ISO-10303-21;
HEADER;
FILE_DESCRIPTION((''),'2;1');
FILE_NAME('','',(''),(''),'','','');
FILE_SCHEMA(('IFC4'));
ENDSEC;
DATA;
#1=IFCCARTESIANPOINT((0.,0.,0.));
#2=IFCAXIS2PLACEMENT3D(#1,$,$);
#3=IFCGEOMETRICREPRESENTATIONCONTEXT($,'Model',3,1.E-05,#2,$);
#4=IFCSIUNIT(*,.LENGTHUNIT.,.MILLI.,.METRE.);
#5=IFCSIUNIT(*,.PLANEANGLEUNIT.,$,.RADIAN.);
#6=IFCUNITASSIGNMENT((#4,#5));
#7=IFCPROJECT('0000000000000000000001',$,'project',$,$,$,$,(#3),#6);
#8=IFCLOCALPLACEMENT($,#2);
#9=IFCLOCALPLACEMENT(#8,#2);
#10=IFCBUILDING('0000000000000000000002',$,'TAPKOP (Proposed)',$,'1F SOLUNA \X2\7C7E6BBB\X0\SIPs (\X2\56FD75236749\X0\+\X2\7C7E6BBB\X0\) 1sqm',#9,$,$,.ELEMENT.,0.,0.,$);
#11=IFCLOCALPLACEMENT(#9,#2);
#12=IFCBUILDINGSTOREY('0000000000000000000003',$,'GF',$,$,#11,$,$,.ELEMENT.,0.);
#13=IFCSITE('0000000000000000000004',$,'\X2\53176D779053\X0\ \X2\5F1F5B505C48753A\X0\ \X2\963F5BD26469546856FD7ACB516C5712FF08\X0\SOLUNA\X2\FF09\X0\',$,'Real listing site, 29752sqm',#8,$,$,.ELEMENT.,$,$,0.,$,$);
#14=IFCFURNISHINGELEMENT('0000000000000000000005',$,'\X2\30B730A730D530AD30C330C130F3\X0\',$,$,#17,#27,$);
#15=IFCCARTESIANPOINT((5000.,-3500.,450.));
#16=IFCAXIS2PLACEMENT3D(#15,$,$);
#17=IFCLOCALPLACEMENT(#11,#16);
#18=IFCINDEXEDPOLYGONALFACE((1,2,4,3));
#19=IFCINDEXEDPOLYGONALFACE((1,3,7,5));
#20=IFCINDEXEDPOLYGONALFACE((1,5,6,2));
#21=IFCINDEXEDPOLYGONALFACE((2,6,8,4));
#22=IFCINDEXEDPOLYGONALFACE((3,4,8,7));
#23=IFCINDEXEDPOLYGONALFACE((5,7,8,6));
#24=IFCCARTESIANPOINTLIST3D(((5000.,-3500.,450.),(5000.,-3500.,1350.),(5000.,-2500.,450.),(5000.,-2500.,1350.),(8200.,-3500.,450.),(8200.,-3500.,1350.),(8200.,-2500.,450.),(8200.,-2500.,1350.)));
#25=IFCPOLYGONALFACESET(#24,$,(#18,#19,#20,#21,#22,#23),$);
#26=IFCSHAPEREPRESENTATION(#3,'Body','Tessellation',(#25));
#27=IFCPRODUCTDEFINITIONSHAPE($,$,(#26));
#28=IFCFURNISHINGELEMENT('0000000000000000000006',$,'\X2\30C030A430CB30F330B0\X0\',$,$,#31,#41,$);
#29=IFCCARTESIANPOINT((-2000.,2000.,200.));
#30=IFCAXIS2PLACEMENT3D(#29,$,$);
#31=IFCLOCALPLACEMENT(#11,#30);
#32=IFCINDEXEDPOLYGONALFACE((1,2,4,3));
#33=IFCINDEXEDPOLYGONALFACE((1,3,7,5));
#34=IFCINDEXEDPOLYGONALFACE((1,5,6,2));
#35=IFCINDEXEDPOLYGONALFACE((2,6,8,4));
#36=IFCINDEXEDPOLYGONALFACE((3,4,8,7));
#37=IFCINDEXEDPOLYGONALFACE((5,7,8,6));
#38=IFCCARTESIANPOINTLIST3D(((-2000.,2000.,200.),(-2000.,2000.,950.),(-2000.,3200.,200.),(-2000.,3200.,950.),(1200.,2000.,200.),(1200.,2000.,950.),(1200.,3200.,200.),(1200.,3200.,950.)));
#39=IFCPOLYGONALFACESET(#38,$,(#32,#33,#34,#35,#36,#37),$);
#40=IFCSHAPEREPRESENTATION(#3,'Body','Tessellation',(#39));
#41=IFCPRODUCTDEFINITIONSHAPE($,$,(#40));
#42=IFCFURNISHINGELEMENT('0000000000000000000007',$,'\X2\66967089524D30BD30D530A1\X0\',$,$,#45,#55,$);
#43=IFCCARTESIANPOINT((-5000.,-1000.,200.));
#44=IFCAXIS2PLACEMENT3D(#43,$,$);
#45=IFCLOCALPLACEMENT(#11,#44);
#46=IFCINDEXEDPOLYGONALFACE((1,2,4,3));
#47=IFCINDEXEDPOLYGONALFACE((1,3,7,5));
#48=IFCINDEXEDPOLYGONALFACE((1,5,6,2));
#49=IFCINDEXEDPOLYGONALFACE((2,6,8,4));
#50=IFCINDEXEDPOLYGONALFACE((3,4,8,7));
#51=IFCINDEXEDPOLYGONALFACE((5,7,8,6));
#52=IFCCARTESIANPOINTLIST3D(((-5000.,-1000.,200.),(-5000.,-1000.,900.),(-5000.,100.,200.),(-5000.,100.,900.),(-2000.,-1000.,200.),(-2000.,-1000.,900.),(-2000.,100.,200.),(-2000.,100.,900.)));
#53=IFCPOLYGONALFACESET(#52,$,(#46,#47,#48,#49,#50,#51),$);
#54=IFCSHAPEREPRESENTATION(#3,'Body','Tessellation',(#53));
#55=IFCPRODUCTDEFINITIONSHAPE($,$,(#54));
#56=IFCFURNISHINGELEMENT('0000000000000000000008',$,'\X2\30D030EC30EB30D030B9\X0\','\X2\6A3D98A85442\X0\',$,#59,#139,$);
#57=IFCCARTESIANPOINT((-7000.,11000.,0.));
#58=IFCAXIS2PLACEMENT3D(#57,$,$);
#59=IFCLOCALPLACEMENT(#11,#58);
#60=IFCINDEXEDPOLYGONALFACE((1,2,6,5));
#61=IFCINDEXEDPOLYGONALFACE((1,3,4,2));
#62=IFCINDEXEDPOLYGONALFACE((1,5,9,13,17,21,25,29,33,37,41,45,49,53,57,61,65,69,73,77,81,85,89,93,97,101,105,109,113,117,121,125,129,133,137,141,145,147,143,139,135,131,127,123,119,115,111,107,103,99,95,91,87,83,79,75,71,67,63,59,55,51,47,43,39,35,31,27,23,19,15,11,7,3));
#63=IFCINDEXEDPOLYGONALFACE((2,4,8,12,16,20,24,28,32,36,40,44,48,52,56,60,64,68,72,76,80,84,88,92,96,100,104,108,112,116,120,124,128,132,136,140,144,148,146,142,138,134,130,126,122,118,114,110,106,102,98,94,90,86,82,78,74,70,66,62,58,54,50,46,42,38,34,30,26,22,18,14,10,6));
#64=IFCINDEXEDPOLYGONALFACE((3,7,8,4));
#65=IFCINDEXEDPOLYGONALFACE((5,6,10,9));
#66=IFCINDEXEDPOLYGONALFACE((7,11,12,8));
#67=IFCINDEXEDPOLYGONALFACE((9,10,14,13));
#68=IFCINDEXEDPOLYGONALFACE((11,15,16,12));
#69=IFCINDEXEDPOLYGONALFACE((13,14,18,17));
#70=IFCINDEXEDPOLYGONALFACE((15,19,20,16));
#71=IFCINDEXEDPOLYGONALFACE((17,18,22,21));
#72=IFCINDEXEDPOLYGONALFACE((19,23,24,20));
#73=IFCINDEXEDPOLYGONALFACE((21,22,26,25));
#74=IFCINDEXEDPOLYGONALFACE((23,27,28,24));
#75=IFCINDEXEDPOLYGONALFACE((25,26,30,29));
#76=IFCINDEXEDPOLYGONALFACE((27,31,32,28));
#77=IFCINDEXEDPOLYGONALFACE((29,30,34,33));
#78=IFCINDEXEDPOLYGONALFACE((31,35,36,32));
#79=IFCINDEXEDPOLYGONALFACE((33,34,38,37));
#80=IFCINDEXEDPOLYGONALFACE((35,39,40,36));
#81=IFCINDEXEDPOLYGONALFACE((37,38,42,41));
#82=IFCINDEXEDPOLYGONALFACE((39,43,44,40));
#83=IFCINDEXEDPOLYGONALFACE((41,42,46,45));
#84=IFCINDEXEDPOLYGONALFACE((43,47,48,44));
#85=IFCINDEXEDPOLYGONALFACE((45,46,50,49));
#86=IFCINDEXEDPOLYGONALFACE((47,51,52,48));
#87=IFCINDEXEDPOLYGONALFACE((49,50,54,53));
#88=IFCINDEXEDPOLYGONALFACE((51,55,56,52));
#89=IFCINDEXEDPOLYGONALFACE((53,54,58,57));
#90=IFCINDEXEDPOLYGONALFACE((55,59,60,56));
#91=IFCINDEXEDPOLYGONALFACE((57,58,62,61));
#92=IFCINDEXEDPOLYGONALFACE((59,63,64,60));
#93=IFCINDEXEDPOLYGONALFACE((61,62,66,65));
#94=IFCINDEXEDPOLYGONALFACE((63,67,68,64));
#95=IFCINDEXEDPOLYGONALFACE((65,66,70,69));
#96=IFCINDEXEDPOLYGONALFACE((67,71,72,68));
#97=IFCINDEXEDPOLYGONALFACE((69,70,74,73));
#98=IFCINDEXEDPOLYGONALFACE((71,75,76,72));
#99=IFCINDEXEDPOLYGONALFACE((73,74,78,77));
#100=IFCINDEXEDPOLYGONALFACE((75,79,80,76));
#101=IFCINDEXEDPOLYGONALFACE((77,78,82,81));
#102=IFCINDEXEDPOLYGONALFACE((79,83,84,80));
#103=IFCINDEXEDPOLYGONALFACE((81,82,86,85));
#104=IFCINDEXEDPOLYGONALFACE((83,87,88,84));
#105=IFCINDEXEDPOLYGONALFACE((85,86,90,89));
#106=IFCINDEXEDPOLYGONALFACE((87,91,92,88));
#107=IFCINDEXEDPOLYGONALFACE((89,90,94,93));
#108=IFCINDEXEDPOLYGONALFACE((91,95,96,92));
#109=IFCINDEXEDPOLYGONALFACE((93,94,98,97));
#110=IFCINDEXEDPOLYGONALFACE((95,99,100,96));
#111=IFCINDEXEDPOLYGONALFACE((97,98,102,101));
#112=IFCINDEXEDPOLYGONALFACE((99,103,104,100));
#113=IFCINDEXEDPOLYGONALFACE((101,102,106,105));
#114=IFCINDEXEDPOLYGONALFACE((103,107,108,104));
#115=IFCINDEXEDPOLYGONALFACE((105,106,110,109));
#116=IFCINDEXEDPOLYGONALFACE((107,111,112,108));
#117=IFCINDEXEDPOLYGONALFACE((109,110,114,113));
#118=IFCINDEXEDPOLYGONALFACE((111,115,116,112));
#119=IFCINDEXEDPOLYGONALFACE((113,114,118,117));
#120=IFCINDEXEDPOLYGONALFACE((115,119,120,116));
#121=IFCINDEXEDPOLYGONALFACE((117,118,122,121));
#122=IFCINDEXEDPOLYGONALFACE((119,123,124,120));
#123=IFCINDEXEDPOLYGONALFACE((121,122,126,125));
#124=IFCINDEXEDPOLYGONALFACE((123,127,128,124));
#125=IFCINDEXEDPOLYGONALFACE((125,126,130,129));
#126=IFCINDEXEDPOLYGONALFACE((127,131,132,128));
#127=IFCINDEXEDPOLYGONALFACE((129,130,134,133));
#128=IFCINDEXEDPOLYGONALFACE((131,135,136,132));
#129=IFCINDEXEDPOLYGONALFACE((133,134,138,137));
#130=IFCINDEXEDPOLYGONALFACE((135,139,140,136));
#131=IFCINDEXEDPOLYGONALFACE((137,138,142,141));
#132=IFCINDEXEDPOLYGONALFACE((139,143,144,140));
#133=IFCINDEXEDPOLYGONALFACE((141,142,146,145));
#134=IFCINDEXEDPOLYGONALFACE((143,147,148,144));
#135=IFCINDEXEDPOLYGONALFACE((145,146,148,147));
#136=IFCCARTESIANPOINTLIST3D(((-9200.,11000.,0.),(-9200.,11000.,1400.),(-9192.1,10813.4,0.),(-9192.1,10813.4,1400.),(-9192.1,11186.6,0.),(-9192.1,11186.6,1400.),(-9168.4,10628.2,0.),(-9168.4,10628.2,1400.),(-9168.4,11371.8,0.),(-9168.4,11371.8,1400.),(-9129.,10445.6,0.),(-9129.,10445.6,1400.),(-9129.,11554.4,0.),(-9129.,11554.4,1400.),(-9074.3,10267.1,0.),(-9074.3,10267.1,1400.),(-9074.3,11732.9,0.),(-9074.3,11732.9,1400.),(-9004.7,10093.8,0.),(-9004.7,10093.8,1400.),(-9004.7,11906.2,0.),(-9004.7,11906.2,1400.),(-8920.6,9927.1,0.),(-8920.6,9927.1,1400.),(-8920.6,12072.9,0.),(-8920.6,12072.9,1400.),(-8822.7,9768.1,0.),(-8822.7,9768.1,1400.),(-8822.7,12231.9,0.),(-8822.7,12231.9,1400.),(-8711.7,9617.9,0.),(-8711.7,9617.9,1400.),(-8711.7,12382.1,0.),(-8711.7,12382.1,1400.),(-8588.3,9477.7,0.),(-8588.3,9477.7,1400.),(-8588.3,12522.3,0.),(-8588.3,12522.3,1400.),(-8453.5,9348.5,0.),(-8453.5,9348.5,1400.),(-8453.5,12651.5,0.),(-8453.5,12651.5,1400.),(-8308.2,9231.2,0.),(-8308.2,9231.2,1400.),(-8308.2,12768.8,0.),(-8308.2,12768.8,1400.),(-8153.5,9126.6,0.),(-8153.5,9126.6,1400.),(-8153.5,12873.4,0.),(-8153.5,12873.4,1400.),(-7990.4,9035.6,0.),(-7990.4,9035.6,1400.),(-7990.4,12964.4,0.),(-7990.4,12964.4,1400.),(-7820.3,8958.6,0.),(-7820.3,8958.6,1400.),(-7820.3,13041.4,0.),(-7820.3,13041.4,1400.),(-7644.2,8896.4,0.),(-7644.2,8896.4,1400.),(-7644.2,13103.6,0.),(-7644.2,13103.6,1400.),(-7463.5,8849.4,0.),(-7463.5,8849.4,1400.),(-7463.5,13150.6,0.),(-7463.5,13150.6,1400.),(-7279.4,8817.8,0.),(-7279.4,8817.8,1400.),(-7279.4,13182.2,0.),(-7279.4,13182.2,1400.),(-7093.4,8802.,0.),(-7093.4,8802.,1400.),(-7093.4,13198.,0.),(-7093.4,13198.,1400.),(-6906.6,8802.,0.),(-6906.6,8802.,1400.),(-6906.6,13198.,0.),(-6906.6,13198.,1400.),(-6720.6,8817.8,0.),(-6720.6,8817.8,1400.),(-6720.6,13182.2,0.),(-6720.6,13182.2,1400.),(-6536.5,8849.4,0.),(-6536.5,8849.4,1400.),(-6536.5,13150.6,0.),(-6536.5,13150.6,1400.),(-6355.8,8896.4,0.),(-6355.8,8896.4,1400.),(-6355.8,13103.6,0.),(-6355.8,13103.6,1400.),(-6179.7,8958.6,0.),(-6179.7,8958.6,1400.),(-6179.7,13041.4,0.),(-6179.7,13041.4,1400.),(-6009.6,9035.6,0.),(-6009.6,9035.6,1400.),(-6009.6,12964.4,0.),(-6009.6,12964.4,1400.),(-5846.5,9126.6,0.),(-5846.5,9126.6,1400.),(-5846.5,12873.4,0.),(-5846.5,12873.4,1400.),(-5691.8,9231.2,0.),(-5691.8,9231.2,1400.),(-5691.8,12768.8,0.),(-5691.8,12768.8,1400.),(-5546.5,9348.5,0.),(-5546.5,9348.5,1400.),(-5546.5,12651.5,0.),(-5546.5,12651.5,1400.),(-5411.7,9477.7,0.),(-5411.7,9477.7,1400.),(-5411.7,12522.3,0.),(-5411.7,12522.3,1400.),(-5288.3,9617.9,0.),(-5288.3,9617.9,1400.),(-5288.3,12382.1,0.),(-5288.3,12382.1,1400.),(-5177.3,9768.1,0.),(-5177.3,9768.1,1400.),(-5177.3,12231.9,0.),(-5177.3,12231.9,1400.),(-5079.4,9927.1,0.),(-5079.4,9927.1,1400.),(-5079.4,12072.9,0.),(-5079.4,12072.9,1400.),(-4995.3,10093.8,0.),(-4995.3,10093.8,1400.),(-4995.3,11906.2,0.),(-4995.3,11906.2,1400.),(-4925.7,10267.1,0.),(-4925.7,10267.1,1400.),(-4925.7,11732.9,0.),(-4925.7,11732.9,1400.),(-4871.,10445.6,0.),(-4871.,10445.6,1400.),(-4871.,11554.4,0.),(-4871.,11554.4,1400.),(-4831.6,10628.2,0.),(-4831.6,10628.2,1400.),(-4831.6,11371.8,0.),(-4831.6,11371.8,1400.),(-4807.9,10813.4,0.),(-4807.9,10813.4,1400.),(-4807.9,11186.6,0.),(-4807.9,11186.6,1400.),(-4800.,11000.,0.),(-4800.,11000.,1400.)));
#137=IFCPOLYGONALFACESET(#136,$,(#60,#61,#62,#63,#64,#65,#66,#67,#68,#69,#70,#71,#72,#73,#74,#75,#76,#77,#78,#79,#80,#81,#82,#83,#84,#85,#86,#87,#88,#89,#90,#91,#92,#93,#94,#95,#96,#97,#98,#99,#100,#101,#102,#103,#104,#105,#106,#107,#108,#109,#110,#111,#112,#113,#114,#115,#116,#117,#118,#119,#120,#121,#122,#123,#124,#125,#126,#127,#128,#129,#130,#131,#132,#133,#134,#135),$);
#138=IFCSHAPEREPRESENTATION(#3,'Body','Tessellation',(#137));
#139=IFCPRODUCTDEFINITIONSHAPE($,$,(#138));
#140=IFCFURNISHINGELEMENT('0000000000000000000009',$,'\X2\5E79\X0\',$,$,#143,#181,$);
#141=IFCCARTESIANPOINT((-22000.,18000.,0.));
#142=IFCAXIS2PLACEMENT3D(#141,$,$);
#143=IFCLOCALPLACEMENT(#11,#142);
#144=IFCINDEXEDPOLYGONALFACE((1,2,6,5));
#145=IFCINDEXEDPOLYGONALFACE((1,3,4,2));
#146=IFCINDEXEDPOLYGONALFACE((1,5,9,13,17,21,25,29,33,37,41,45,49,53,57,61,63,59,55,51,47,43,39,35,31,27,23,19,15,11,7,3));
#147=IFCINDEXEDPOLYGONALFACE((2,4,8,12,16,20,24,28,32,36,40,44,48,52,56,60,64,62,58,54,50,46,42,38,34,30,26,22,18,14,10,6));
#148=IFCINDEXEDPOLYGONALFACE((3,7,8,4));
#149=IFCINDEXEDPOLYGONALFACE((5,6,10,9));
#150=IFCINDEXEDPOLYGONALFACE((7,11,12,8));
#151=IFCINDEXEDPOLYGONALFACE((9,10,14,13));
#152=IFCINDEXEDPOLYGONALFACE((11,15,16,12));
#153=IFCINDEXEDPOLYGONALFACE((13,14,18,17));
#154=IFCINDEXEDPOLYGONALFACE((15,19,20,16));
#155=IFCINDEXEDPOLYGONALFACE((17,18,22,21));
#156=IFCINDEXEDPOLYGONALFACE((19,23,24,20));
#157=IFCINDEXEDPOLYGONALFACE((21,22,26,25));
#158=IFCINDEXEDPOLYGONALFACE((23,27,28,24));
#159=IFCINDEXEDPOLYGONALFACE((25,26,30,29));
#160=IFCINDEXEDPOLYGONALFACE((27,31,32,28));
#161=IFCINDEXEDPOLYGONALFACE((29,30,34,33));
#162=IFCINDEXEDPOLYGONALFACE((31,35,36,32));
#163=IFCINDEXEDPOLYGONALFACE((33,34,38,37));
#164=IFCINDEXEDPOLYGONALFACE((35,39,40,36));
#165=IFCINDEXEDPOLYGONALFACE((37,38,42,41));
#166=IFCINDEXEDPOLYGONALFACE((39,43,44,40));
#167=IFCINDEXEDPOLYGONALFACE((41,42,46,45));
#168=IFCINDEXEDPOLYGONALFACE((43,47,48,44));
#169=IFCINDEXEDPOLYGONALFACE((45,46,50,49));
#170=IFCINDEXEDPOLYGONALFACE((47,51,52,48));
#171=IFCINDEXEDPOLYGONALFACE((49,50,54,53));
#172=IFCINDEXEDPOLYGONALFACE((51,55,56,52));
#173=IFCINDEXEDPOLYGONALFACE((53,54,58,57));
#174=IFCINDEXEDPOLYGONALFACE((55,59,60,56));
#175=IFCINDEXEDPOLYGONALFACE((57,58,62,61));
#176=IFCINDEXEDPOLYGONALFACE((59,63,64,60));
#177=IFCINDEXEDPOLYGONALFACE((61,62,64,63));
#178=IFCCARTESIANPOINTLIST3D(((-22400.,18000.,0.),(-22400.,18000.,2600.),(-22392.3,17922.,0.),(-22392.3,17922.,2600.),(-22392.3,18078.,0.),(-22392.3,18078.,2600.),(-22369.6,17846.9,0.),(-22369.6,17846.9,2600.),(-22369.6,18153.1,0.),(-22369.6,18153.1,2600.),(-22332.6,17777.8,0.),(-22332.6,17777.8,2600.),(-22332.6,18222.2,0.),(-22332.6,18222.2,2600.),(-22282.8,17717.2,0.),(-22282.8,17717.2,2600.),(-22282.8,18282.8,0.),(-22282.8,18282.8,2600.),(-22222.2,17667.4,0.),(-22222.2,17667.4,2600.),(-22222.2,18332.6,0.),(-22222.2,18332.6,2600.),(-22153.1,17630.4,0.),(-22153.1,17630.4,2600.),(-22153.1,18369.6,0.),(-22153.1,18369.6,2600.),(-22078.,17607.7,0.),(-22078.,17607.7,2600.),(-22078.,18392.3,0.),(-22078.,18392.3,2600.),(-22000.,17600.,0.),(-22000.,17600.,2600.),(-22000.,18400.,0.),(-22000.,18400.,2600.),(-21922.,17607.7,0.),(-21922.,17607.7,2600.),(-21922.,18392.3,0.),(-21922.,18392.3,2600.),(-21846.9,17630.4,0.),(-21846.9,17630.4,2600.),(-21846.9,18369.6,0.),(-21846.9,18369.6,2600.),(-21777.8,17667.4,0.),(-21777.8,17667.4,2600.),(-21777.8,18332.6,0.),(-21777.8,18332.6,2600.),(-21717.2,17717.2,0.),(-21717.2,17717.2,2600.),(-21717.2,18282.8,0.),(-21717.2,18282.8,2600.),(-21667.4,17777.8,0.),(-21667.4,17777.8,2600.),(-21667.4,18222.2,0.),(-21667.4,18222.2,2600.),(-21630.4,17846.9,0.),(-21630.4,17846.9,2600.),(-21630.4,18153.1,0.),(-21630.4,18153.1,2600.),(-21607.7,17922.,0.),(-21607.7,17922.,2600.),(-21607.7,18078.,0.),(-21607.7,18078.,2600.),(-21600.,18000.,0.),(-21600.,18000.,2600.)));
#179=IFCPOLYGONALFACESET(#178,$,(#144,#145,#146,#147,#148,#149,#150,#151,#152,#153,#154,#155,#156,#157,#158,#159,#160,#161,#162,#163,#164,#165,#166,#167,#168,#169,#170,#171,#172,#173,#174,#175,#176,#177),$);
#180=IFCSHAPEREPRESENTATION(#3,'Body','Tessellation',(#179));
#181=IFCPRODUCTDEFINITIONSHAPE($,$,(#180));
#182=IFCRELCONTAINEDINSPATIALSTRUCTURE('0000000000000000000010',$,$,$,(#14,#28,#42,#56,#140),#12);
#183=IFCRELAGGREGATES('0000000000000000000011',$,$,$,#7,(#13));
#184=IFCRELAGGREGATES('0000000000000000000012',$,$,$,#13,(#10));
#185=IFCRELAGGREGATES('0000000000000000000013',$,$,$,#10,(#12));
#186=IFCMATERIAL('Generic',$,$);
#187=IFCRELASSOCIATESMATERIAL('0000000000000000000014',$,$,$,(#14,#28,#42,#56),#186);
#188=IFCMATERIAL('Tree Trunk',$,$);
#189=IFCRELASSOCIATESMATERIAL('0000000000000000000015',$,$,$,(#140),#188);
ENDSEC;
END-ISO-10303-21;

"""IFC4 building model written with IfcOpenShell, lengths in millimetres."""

from ifc_helpers import new_model, si_unit, frame, frame_2d, origin, origin_2d, place, context, project, spatial, rectangle, circle, extrude, material, element, save


model = new_model("IFC4")

# Units and contexts
model_context = context("Model", 3, precision=1e-05, world=origin())
ifc_project = project(units=[si_unit("LENGTHUNIT", "METRE", prefix="MILLI"), si_unit("PLANEANGLEUNIT", "RADIAN")], contexts=[model_context])

# Site, building, storey
site_placement = place(None, origin())
site = spatial("IfcSite", under=ifc_project, at=site_placement, Name="北海道 弟子屈町 阿寒摩周国立公園（SOLUNA）", ObjectType="Real listing site, 29752sqm", CompositionType="ELEMENT", RefElevation=0.0)
building_placement = place(site_placement, origin())
building = spatial("IfcBuilding", under=site, at=building_placement, Name="TAPKOP (Proposed)", ObjectType="1F SOLUNA 籾殻SIPs (国産杉+籾殻) 1sqm", CompositionType="ELEMENT", ElevationOfRefHeight=0.0, ElevationOfTerrain=0.0)
storey_placement = place(building_placement, origin())
storey = spatial("IfcBuildingStorey", under=building, at=storey_placement, Name="GF", CompositionType="ELEMENT", Elevation=0.0)

# Shared definitions
ifc_material_1 = material(Name="Generic")

# Furnishing elements
furnishing_1_placement = place(storey_placement, frame((5000.0, -3500.0, 450.0)))
element("IfcFurnishingElement", 1, at=furnishing_1_placement, inside=storey, material=ifc_material_1, Name="シェフキッチン", context=model_context, shape_type="SweptSolid", body=[
    extrude(rectangle(XDim=3200.0, YDim=1000.0, at=frame_2d((1600.0, 500.0))), frame((5000.0, -3500.0, 450.0)), (0.0, 0.0, 1.0), 900.0),
])
furnishing_2_placement = place(storey_placement, frame((-2000.0, 2000.0, 200.0)))
element("IfcFurnishingElement", 2, at=furnishing_2_placement, inside=storey, material=ifc_material_1, Name="ダイニング", context=model_context, shape_type="SweptSolid", body=[
    extrude(rectangle(XDim=3200.0, YDim=1200.0, at=frame_2d((1600.0, 600.0))), frame((-2000.0, 2000.0, 200.0)), (0.0, 0.0, 1.0), 750.0),
])
furnishing_3_placement = place(storey_placement, frame((-5000.0, -1000.0, 200.0)))
element("IfcFurnishingElement", 3, at=furnishing_3_placement, inside=storey, material=ifc_material_1, Name="暖炉前ソファ", context=model_context, shape_type="SweptSolid", body=[
    extrude(rectangle(XDim=3000.0, YDim=1100.0, at=frame_2d((1500.0, 550.0))), frame((-5000.0, -1000.0, 200.0)), (0.0, 0.0, 1.0), 700.0),
])
furnishing_4_placement = place(storey_placement, frame((-7000.0, 11000.0, 0.0)))
element("IfcFurnishingElement", 4, at=furnishing_4_placement, inside=storey, material=ifc_material_1, Name="バレルバス", Description="樽風呂", context=model_context, shape_type="SweptSolid", body=[
    extrude(circle(Radius=2200.0, at=origin_2d()), frame((-7000.0, 11000.0, 0.0)), (0.0, 0.0, 1.0), 1400.0),
])
ifc_material_2 = material(Name="Tree Trunk")
furnishing_5_placement = place(storey_placement, frame((-22000.0, 18000.0, 0.0)))
element("IfcFurnishingElement", 5, at=furnishing_5_placement, inside=storey, material=ifc_material_2, Name="幹", context=model_context, shape_type="SweptSolid", body=[
    extrude(circle(Radius=400.0, at=origin_2d()), frame((-22000.0, 18000.0, 0.0)), (0.0, 0.0, 1.0), 2600.0),
])

save(model, "model.ifc")
